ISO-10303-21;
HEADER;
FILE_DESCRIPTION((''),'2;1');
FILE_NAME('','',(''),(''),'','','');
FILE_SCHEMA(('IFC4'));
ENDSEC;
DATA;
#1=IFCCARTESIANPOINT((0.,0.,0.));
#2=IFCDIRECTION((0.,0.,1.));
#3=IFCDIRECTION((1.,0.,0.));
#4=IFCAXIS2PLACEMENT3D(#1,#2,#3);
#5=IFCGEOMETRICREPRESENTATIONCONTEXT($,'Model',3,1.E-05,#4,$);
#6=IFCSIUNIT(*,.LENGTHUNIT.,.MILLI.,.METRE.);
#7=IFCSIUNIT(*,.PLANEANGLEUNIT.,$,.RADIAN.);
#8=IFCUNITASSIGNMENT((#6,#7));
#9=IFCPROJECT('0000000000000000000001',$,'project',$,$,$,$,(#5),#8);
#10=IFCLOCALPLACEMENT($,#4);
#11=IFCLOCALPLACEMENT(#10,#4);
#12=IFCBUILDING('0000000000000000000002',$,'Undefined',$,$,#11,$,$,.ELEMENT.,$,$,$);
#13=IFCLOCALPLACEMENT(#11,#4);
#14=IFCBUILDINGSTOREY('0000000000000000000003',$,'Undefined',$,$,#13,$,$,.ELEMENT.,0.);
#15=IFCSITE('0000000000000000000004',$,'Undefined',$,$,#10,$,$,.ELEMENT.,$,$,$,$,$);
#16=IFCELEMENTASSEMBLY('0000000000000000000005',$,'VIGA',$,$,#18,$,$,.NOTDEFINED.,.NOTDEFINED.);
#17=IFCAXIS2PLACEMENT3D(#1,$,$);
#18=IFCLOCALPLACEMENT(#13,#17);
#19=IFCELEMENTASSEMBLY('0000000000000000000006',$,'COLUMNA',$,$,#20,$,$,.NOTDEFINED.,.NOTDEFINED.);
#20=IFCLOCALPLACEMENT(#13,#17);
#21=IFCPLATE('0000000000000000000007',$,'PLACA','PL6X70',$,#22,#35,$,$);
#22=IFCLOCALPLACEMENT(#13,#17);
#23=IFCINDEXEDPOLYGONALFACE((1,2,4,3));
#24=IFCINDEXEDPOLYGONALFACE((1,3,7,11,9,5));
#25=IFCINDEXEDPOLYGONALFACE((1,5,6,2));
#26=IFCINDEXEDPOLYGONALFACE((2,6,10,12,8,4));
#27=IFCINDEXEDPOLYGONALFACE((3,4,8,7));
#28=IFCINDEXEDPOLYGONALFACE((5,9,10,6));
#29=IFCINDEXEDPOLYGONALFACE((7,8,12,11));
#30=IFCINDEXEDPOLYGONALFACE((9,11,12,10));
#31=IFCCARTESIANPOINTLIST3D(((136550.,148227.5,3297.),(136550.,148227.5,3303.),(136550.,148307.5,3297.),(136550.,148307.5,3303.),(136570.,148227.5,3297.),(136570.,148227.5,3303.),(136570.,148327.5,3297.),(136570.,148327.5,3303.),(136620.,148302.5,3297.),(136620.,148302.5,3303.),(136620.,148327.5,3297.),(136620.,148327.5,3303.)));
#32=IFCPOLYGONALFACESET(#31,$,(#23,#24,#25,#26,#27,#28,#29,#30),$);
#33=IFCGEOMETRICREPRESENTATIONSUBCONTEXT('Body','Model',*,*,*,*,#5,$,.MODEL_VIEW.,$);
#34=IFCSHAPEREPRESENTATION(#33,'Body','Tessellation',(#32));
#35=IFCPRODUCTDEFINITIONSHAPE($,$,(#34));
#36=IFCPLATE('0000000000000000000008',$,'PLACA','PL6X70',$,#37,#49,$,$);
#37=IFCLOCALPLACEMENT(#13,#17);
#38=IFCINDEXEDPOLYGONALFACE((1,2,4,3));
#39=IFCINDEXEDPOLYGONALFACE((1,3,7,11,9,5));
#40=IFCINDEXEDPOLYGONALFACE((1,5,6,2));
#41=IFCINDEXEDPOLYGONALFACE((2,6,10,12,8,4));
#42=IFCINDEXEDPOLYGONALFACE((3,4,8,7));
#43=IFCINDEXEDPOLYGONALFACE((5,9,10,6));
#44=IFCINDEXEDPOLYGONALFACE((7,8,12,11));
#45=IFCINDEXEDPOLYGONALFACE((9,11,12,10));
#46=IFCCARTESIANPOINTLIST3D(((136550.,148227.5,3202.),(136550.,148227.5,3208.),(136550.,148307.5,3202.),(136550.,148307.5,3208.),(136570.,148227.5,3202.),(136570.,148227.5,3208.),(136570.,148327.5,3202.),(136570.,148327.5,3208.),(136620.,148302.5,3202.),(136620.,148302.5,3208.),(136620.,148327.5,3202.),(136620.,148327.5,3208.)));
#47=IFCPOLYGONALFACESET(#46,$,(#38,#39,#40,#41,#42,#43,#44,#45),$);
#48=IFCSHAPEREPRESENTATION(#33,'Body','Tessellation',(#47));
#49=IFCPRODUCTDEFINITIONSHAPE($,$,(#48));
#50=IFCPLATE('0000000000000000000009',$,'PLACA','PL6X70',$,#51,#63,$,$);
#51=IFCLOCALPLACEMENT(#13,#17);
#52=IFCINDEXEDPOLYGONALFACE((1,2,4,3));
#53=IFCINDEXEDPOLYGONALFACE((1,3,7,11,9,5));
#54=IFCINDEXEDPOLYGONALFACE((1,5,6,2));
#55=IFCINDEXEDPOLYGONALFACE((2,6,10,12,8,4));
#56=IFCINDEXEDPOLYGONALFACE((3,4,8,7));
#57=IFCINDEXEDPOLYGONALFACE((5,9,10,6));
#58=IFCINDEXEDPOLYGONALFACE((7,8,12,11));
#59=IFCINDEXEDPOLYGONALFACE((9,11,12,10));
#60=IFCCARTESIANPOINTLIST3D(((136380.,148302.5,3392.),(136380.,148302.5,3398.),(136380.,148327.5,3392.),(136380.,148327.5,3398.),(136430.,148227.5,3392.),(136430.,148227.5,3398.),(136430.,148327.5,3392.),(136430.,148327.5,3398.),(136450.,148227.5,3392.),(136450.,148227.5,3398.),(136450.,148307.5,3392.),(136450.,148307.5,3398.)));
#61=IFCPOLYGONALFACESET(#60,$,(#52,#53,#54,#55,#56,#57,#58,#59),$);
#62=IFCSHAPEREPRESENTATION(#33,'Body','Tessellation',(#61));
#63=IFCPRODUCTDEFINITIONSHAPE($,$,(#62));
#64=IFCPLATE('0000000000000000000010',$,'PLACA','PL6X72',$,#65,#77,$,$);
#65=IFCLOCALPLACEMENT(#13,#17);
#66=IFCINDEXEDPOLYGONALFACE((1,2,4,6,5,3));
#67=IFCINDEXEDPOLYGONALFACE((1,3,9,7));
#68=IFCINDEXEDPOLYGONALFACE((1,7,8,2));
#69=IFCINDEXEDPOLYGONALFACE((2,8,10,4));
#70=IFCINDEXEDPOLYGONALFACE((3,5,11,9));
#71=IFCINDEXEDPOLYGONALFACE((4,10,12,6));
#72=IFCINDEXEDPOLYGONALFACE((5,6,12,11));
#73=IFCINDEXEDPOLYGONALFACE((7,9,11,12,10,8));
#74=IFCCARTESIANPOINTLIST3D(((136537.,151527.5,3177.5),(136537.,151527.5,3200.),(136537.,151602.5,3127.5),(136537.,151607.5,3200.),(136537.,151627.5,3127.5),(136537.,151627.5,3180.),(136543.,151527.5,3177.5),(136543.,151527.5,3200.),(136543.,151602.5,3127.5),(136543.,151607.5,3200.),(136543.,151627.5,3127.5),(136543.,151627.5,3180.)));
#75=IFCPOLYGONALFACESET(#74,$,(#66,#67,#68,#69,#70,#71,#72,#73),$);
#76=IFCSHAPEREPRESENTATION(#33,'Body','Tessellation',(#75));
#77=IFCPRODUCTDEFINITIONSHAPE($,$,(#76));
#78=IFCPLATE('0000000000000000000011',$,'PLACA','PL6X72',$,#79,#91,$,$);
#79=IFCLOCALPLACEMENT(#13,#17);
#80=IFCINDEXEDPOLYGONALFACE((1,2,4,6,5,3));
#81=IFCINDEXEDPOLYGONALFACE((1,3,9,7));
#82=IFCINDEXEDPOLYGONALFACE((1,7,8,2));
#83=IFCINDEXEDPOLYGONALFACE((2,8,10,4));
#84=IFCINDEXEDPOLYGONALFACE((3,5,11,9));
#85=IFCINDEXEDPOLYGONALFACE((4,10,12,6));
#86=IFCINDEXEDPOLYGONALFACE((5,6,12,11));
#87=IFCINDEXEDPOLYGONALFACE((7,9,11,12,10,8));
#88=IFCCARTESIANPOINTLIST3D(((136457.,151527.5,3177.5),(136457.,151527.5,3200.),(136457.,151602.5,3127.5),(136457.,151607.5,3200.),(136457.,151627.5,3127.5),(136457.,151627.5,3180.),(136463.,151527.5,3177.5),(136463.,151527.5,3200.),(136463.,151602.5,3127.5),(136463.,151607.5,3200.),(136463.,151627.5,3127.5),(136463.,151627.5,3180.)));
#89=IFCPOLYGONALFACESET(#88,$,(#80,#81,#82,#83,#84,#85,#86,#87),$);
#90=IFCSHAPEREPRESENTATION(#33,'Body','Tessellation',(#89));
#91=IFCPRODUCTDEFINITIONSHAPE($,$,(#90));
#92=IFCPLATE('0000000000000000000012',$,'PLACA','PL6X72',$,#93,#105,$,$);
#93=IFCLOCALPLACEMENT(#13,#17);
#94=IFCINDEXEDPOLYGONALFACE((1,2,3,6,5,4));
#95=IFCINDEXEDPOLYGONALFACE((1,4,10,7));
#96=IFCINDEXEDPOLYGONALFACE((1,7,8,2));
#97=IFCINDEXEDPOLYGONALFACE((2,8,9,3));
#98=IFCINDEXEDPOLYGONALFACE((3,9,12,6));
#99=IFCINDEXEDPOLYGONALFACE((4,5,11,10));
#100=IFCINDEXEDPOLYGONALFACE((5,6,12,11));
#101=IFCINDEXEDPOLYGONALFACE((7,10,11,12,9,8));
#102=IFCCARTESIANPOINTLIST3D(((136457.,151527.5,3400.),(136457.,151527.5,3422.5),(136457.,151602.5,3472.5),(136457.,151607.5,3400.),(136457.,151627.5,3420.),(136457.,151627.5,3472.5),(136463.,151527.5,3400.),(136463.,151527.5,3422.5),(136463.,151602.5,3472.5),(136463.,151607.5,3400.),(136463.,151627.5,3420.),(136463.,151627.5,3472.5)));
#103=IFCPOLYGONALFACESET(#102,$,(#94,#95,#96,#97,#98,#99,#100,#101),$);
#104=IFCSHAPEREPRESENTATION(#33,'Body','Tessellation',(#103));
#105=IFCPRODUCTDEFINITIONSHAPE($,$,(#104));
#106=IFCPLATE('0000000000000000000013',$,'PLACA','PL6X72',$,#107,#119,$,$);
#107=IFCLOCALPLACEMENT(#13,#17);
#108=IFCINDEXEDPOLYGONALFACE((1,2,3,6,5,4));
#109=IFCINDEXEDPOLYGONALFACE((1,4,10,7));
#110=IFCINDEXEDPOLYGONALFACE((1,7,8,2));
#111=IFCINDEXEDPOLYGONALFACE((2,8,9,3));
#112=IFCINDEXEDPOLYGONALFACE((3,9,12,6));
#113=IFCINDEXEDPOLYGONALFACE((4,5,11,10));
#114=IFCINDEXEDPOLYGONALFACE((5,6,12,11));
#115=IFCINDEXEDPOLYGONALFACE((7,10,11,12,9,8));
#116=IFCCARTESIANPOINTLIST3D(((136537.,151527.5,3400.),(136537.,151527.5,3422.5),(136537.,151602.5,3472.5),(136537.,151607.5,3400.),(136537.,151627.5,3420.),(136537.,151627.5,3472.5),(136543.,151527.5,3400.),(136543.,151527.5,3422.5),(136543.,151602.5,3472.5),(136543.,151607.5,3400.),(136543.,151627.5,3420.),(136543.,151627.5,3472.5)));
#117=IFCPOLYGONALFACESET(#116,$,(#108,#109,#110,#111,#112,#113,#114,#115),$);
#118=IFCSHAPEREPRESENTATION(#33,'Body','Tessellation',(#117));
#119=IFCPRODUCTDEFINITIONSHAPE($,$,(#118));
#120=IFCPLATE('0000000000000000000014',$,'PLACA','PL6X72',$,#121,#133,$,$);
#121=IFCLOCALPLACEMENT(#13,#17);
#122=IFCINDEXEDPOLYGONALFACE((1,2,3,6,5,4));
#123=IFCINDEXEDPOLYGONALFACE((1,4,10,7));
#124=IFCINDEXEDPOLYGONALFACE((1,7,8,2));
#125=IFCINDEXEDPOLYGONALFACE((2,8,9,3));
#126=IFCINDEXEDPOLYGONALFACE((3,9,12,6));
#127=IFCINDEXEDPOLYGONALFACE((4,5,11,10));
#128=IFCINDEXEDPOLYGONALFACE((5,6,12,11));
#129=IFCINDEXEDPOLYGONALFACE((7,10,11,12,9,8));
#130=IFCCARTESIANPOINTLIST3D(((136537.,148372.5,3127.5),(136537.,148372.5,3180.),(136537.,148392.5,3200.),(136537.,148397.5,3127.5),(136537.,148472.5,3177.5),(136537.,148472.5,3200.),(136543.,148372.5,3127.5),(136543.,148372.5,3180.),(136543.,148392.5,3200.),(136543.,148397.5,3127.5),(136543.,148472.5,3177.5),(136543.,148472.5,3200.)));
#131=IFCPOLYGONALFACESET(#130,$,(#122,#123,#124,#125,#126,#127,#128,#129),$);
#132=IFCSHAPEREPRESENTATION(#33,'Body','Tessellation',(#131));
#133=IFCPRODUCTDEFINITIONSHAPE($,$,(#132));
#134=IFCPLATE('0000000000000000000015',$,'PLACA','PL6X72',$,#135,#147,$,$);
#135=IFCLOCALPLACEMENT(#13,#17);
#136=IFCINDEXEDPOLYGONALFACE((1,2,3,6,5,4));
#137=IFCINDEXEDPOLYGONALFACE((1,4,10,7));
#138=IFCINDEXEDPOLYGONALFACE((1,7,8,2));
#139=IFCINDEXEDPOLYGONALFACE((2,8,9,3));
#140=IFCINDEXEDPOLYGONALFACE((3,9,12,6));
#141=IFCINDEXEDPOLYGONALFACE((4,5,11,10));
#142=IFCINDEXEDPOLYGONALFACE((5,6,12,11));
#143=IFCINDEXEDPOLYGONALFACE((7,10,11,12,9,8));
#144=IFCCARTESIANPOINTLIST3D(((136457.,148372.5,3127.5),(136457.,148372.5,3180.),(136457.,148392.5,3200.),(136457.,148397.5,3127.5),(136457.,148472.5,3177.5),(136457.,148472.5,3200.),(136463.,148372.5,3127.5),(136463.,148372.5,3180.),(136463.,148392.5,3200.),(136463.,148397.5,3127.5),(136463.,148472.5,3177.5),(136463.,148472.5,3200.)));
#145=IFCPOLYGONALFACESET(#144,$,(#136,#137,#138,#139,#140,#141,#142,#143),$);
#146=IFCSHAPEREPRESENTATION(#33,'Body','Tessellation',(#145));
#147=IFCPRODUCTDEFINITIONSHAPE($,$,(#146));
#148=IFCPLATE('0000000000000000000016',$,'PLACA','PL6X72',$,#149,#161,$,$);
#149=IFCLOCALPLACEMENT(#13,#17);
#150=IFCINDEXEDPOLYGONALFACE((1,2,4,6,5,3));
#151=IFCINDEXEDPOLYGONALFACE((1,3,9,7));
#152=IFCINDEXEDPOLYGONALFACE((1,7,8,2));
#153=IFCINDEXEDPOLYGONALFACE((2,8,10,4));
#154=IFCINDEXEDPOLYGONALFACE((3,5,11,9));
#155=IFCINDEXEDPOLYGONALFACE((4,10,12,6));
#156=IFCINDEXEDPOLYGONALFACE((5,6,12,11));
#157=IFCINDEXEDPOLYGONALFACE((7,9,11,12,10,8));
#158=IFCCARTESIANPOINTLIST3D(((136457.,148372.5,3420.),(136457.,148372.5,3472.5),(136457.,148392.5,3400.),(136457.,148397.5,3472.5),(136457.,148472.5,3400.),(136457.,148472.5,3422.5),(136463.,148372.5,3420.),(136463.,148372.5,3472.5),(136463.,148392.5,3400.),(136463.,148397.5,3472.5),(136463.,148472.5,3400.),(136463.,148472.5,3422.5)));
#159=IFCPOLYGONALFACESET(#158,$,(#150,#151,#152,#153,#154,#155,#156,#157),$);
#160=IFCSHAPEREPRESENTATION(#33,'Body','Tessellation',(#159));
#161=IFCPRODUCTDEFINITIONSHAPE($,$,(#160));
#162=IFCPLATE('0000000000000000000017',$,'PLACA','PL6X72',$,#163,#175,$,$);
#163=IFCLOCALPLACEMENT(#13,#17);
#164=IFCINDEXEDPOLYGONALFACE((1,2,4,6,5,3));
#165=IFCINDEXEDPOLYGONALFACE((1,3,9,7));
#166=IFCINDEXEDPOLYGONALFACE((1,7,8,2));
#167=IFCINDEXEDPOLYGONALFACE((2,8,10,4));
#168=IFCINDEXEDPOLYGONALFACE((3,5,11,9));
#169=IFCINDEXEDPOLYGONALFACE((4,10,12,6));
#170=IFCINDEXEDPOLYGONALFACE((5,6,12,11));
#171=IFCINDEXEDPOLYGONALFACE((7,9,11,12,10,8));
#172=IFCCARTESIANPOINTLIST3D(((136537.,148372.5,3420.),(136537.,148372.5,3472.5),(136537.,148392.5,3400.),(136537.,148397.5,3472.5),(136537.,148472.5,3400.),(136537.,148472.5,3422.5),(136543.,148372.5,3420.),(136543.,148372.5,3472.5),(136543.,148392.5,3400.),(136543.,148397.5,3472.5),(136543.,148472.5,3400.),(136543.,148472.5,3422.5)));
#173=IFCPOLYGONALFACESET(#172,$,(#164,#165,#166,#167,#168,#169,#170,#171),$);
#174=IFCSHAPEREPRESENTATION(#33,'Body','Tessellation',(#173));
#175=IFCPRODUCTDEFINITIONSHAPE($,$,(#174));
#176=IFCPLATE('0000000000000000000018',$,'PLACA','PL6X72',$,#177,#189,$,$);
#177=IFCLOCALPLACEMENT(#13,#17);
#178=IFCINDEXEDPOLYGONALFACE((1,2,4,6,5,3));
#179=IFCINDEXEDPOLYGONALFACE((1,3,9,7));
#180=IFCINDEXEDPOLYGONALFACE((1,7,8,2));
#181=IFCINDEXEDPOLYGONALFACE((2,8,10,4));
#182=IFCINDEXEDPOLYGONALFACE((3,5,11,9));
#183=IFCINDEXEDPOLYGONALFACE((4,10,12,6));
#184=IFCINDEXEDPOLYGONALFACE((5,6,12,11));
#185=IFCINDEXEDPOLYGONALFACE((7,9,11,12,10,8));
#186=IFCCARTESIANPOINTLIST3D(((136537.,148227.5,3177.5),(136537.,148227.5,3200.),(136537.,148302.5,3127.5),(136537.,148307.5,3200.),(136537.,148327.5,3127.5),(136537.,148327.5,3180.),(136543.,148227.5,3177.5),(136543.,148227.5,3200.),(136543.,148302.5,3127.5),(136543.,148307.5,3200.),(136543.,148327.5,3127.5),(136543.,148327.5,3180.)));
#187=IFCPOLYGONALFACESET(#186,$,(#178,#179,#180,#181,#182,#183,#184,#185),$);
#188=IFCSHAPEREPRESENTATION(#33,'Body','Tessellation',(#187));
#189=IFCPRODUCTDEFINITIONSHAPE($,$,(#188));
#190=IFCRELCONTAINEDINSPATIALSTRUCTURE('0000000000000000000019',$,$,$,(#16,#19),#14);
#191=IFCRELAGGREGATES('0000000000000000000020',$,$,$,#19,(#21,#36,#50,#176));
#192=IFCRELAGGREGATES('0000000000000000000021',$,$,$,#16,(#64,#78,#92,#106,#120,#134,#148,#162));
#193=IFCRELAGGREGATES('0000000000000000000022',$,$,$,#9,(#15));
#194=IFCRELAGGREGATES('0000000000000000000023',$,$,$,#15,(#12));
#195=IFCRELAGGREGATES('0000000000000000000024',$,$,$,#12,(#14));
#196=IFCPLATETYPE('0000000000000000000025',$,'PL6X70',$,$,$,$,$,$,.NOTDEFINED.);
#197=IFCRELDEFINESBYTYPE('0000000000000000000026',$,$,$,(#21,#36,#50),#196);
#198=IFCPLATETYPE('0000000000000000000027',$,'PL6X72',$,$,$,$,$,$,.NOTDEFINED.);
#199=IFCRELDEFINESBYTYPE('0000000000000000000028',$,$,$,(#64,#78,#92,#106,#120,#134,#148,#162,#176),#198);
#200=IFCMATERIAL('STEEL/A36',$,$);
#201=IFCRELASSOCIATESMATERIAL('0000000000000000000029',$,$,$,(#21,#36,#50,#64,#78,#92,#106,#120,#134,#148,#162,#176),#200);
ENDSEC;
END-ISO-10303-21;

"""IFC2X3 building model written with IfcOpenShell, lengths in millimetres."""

from ifc_helpers import new_model, si_unit, frame, origin_with_axes, place, context, subcontext, project, spatial, polyline, outline, extrude, material, type_object, element, aggregate, save


model = new_model("IFC2X3")

# Units and contexts
model_context = context("Model", 3, precision=1e-05, world=origin_with_axes())
body_context = subcontext(model_context, "Body", "Model", "MODEL_VIEW")
ifc_project = project(units=[si_unit("LENGTHUNIT", "METRE", prefix="MILLI"), si_unit("PLANEANGLEUNIT", "RADIAN")], contexts=[model_context])

# Site, building, storey
site_placement = place(None, origin_with_axes())
site = spatial("IfcSite", under=ifc_project, at=site_placement, Name="Undefined", CompositionType="ELEMENT")
building_placement = place(site_placement, origin_with_axes())
building = spatial("IfcBuilding", under=site, at=building_placement, Name="Undefined", CompositionType="ELEMENT")
storey_placement = place(building_placement, origin_with_axes())
storey = spatial("IfcBuildingStorey", under=building, at=storey_placement, Name="Undefined", CompositionType="ELEMENT", Elevation=0.0)

# Element assembly
assembly_1_placement = place(storey_placement, origin_with_axes())
assembly_1 = element("IfcElementAssembly", 1, at=assembly_1_placement, inside=storey, Name="VIGA", AssemblyPlace="NOTDEFINED", PredefinedType="NOTDEFINED")
ifc_material_1 = material(Name="STEEL/A36")

# Shared definitions
plate_type_1 = type_object("IfcPlateType", Name="PL6X70", PredefinedType="NOTDEFINED")

# Element assembly, plates
assembly_2_placement = place(storey_placement, origin_with_axes())
assembly_2 = element("IfcElementAssembly", 2, at=assembly_2_placement, inside=storey, Name="COLUMNA", AssemblyPlace="NOTDEFINED", PredefinedType="NOTDEFINED")
plate_1_placement = place(assembly_2_placement, frame((136620.0, 148327.5, 3300.0), z_axis=(0.0, 0.0, -1.0), x_axis=(0.0, -1.0, 0.0)))
plate_1 = element("IfcPlate", 3, at=plate_1_placement, type_object=plate_type_1, material=ifc_material_1, Name="PLACA", Description="PL6X70", context=body_context, shape_type="SweptSolid", body=[
    extrude(outline(polyline([(0.0, 0.0), (25.0, 0.0), (100.0, 50.0), (100.0, 70.0), (20.0, 70.0), (0.0, 50.0), (0.0, 0.0)])), frame((0.0, 0.0, -3.0), z_axis=(0.0, 0.0, 1.0), x_axis=(1.0, 0.0, 0.0)), (0.0, 0.0, 1.0), 6.0),
])
plate_2_placement = place(assembly_2_placement, frame((136620.0, 148327.5, 3205.0), z_axis=(0.0, 0.0, -1.0), x_axis=(0.0, -1.0, 0.0)))
plate_2 = element("IfcPlate", 4, at=plate_2_placement, type_object=plate_type_1, material=ifc_material_1, Name="PLACA", Description="PL6X70", context=body_context, shape_type="SweptSolid", body=[
    extrude(outline(polyline([(0.0, 0.0), (25.0, 0.0), (100.0, 50.0), (100.0, 70.0), (20.0, 70.0), (0.0, 50.0), (0.0, 0.0)])), frame((0.0, 0.0, -3.0), z_axis=(0.0, 0.0, 1.0), x_axis=(1.0, 0.0, 0.0)), (0.0, 0.0, 1.0), 6.0),
])
plate_3_placement = place(assembly_2_placement, frame((136380.0, 148327.5, 3395.0), z_axis=(0.0, 0.0, 1.0), x_axis=(0.0, -1.0, 0.0)))
plate_3 = element("IfcPlate", 5, at=plate_3_placement, type_object=plate_type_1, material=ifc_material_1, Name="PLACA", Description="PL6X70", context=body_context, shape_type="SweptSolid", body=[
    extrude(outline(polyline([(0.0, 0.0), (25.0, 0.0), (100.0, 50.0), (100.0, 70.0), (20.0, 70.0), (0.0, 50.0), (0.0, 0.0)])), frame((0.0, 0.0, -3.0), z_axis=(0.0, 0.0, 1.0), x_axis=(1.0, 0.0, 0.0)), (0.0, 0.0, 1.0), 6.0),
])

# Plates
plate_type_2 = type_object("IfcPlateType", Name="PL6X72", PredefinedType="NOTDEFINED")
plate_4_placement = place(assembly_1_placement, frame((136540.0, 151627.5, 3127.5), z_axis=(-1.0, 0.0, 0.0), x_axis=(0.0, -1.0, 0.0)))
plate_4 = element("IfcPlate", 6, at=plate_4_placement, type_object=plate_type_2, material=ifc_material_1, Name="PLACA", Description="PL6X72", context=body_context, shape_type="SweptSolid", body=[
    extrude(outline(polyline([(0.0, 0.0), (25.0, 0.0), (100.0, 50.0), (100.0, 72.5), (20.0, 72.5), (0.0, 52.5), (0.0, 0.0)])), frame((0.0, 0.0, -3.0), z_axis=(0.0, 0.0, 1.0), x_axis=(1.0, 0.0, 0.0)), (0.0, 0.0, 1.0), 6.0),
])
plate_5_placement = place(assembly_1_placement, frame((136460.0, 151627.5, 3127.5), z_axis=(-1.0, 0.0, 0.0), x_axis=(0.0, -1.0, 0.0)))
plate_5 = element("IfcPlate", 7, at=plate_5_placement, type_object=plate_type_2, material=ifc_material_1, Name="PLACA", Description="PL6X72", context=body_context, shape_type="SweptSolid", body=[
    extrude(outline(polyline([(0.0, 0.0), (25.0, 0.0), (100.0, 50.0), (100.0, 72.5), (20.0, 72.5), (0.0, 52.5), (0.0, 0.0)])), frame((0.0, 0.0, -3.0), z_axis=(0.0, 0.0, 1.0), x_axis=(1.0, 0.0, 0.0)), (0.0, 0.0, 1.0), 6.0),
])
plate_6_placement = place(assembly_1_placement, frame((136460.0, 151627.5, 3472.5), z_axis=(1.0, 0.0, 0.0), x_axis=(0.0, -1.0, 0.0)))
plate_6 = element("IfcPlate", 8, at=plate_6_placement, type_object=plate_type_2, material=ifc_material_1, Name="PLACA", Description="PL6X72", context=body_context, shape_type="SweptSolid", body=[
    extrude(outline(polyline([(0.0, 0.0), (25.0, 0.0), (100.0, 50.0), (100.0, 72.5), (20.0, 72.5), (0.0, 52.5), (0.0, 0.0)])), frame((0.0, 0.0, -3.0), z_axis=(0.0, 0.0, 1.0), x_axis=(1.0, 0.0, 0.0)), (0.0, 0.0, 1.0), 6.0),
])
plate_7_placement = place(assembly_1_placement, frame((136540.0, 151627.5, 3472.5), z_axis=(1.0, 0.0, 0.0), x_axis=(0.0, -1.0, 0.0)))
plate_7 = element("IfcPlate", 9, at=plate_7_placement, type_object=plate_type_2, material=ifc_material_1, Name="PLACA", Description="PL6X72", context=body_context, shape_type="SweptSolid", body=[
    extrude(outline(polyline([(0.0, 0.0), (25.0, 0.0), (100.0, 50.0), (100.0, 72.5), (20.0, 72.5), (0.0, 52.5), (0.0, 0.0)])), frame((0.0, 0.0, -3.0), z_axis=(0.0, 0.0, 1.0), x_axis=(1.0, 0.0, 0.0)), (0.0, 0.0, 1.0), 6.0),
])
plate_8_placement = place(assembly_1_placement, frame((136540.0, 148372.5, 3127.5), z_axis=(1.0, 0.0, 0.0), x_axis=(0.0, 1.0, 0.0)))
plate_8 = element("IfcPlate", 10, at=plate_8_placement, type_object=plate_type_2, material=ifc_material_1, Name="PLACA", Description="PL6X72", context=body_context, shape_type="SweptSolid", body=[
    extrude(outline(polyline([(0.0, 0.0), (25.0, 0.0), (100.0, 50.0), (100.0, 72.5), (20.0, 72.5), (0.0, 52.5), (0.0, 0.0)])), frame((0.0, 0.0, -3.0), z_axis=(0.0, 0.0, 1.0), x_axis=(1.0, 0.0, 0.0)), (0.0, 0.0, 1.0), 6.0),
])
plate_9_placement = place(assembly_1_placement, frame((136460.0, 148372.5, 3127.5), z_axis=(1.0, 0.0, 0.0), x_axis=(0.0, 1.0, 0.0)))
plate_9 = element("IfcPlate", 11, at=plate_9_placement, type_object=plate_type_2, material=ifc_material_1, Name="PLACA", Description="PL6X72", context=body_context, shape_type="SweptSolid", body=[
    extrude(outline(polyline([(0.0, 0.0), (25.0, 0.0), (100.0, 50.0), (100.0, 72.5), (20.0, 72.5), (0.0, 52.5), (0.0, 0.0)])), frame((0.0, 0.0, -3.0), z_axis=(0.0, 0.0, 1.0), x_axis=(1.0, 0.0, 0.0)), (0.0, 0.0, 1.0), 6.0),
])
plate_10_placement = place(assembly_1_placement, frame((136460.0, 148372.5, 3472.5), z_axis=(-1.0, 0.0, 0.0), x_axis=(0.0, 1.0, 0.0)))
plate_10 = element("IfcPlate", 12, at=plate_10_placement, type_object=plate_type_2, material=ifc_material_1, Name="PLACA", Description="PL6X72", context=body_context, shape_type="SweptSolid", body=[
    extrude(outline(polyline([(0.0, 0.0), (25.0, 0.0), (100.0, 50.0), (100.0, 72.5), (20.0, 72.5), (0.0, 52.5), (0.0, 0.0)])), frame((0.0, 0.0, -3.0), z_axis=(0.0, 0.0, 1.0), x_axis=(1.0, 0.0, 0.0)), (0.0, 0.0, 1.0), 6.0),
])
plate_11_placement = place(assembly_1_placement, frame((136540.0, 148372.5, 3472.5), z_axis=(-1.0, 0.0, 0.0), x_axis=(0.0, 1.0, 0.0)))
plate_11 = element("IfcPlate", 13, at=plate_11_placement, type_object=plate_type_2, material=ifc_material_1, Name="PLACA", Description="PL6X72", context=body_context, shape_type="SweptSolid", body=[
    extrude(outline(polyline([(0.0, 0.0), (25.0, 0.0), (100.0, 50.0), (100.0, 72.5), (20.0, 72.5), (0.0, 52.5), (0.0, 0.0)])), frame((0.0, 0.0, -3.0), z_axis=(0.0, 0.0, 1.0), x_axis=(1.0, 0.0, 0.0)), (0.0, 0.0, 1.0), 6.0),
])
plate_12_placement = place(assembly_2_placement, frame((136540.0, 148327.5, 3127.5), z_axis=(-1.0, 0.0, 0.0), x_axis=(0.0, -1.0, 0.0)))
plate_12 = element("IfcPlate", 14, at=plate_12_placement, type_object=plate_type_2, material=ifc_material_1, Name="PLACA", Description="PL6X72", context=body_context, shape_type="SweptSolid", body=[
    extrude(outline(polyline([(0.0, 0.0), (25.0, 0.0), (100.0, 50.0), (100.0, 72.5), (20.0, 72.5), (0.0, 52.5), (0.0, 0.0)])), frame((0.0, 0.0, -3.0), z_axis=(0.0, 0.0, 1.0), x_axis=(1.0, 0.0, 0.0)), (0.0, 0.0, 1.0), 6.0),
])
aggregate(assembly_2, [plate_1, plate_2, plate_3, plate_12])

aggregate(assembly_1, [plate_4, plate_5, plate_6, plate_7, plate_8, plate_9, plate_10, plate_11])

save(model, "model.ifc")
